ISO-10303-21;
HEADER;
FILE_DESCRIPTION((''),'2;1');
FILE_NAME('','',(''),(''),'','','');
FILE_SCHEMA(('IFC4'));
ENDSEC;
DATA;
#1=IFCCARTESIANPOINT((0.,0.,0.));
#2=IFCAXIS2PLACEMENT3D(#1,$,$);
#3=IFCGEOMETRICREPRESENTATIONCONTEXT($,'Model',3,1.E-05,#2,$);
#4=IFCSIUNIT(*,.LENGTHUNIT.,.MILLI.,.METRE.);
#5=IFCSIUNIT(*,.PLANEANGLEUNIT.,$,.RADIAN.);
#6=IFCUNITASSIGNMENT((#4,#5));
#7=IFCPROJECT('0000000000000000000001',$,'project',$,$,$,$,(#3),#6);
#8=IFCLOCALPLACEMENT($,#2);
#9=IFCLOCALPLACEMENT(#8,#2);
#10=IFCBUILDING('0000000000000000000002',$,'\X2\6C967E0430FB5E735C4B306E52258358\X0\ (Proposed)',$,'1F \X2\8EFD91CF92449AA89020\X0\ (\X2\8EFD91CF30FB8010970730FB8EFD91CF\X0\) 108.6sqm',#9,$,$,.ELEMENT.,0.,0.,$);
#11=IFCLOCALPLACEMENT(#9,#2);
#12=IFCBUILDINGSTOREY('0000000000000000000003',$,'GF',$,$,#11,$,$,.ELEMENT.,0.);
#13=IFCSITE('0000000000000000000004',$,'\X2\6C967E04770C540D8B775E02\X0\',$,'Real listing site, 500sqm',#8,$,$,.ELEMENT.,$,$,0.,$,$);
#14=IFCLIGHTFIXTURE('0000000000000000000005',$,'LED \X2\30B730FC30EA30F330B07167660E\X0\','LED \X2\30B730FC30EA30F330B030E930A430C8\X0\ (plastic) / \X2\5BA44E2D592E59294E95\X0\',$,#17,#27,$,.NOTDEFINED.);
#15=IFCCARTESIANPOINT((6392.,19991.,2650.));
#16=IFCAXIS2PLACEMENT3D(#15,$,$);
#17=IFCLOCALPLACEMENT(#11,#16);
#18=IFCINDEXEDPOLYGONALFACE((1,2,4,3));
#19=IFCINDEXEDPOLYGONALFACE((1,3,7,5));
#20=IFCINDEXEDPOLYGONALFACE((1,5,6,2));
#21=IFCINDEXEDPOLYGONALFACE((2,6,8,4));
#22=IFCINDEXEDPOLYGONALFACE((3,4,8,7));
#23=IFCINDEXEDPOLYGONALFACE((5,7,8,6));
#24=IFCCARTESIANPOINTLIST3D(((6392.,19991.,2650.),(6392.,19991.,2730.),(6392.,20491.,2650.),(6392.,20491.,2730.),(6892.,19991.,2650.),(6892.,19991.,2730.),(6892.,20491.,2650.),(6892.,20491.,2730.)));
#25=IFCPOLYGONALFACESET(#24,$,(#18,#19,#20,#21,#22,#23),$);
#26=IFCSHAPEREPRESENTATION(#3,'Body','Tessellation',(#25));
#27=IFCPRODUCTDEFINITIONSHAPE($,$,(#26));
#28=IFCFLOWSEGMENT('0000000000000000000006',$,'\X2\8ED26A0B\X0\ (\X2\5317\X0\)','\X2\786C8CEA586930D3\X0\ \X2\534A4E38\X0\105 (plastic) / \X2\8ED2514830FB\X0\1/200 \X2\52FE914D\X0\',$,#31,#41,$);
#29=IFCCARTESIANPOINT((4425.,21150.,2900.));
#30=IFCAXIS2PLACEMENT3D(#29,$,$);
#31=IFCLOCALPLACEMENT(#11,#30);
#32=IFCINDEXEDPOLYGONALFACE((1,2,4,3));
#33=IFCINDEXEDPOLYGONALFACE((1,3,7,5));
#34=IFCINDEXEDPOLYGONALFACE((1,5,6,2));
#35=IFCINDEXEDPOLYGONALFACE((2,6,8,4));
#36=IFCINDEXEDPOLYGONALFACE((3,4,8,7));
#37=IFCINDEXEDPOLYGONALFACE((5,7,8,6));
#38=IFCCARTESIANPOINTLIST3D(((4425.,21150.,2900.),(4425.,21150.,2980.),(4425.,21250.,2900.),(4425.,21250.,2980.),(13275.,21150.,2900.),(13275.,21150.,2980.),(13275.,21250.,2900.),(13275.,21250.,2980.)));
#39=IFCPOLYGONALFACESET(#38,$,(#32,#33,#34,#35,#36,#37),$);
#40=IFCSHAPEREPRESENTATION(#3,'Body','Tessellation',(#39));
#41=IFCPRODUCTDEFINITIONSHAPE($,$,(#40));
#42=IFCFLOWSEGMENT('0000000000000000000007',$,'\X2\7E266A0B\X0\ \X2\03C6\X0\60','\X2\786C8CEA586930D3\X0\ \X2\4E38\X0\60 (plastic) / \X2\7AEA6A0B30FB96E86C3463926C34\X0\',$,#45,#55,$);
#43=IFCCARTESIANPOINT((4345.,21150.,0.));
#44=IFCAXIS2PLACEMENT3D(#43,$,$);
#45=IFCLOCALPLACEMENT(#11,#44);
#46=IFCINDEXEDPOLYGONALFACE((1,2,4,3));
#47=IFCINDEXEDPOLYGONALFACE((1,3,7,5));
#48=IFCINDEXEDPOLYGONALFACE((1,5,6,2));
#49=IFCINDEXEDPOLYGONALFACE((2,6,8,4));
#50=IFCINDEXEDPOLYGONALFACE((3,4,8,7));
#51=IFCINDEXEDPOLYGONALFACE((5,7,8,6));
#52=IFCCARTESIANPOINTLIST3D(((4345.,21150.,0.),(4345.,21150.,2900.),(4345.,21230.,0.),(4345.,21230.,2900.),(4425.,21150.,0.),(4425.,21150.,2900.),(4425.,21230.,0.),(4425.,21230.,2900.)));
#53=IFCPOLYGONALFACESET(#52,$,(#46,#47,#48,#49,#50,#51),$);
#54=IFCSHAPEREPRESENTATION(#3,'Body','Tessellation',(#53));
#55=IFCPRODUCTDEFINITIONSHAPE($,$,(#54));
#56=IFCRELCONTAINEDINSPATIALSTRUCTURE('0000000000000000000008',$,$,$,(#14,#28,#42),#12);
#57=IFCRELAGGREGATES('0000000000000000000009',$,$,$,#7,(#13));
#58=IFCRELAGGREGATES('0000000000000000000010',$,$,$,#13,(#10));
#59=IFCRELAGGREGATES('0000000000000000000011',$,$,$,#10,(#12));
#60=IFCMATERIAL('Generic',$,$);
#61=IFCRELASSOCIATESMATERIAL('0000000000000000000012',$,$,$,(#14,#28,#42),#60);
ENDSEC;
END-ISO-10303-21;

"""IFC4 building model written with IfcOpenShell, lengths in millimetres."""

from ifc_helpers import new_model, si_unit, frame, frame_2d, origin, place, context, project, spatial, rectangle, extrude, material, element, save


model = new_model("IFC4")

# Units and contexts
model_context = context("Model", 3, precision=1e-05, world=origin())
ifc_project = project(units=[si_unit("LENGTHUNIT", "METRE", prefix="MILLI"), si_unit("PLANEANGLEUNIT", "RADIAN")], contexts=[model_context])

# Site, building, storey
site_placement = place(None, origin())
site = spatial("IfcSite", under=ifc_project, at=site_placement, Name="沖縄県名護市", ObjectType="Real listing site, 500sqm", CompositionType="ELEMENT", RefElevation=0.0)
building_placement = place(site_placement, origin())
building = spatial("IfcBuilding", under=site, at=building_placement, Name="沖縄・平屋の別荘 (Proposed)", ObjectType="1F 軽量鉄骨造 (軽量・耐震・軽量) 108.6sqm", CompositionType="ELEMENT", ElevationOfRefHeight=0.0, ElevationOfTerrain=0.0)
storey_placement = place(building_placement, origin())
storey = spatial("IfcBuildingStorey", under=building, at=storey_placement, Name="GF", CompositionType="ELEMENT", Elevation=0.0)

# Shared definitions
ifc_material_1 = material(Name="Generic")

# Light fixture
light_fixture_placement = place(storey_placement, frame((6392.0, 19991.0, 2650.0)))
element("IfcLightFixture", 1, at=light_fixture_placement, inside=storey, material=ifc_material_1, Name="LED シーリング照明", Description="LED シーリングライト (plastic) / 室中央天井", PredefinedType="NOTDEFINED", context=model_context, shape_type="SweptSolid", body=[
    extrude(rectangle(XDim=500.0, YDim=500.0, at=frame_2d((250.0, 250.0))), frame((6392.0, 19991.0, 2650.0)), (0.0, 0.0, 1.0), 80.0),
])

# Flow segments
flow_segment_1_placement = place(storey_placement, frame((4425.0, 21150.0, 2900.0)))
element("IfcFlowSegment", 2, at=flow_segment_1_placement, inside=storey, material=ifc_material_1, Name="軒樋 (北)", Description="硬質塩ビ 半丸105 (plastic) / 軒先・1/200 勾配", context=model_context, shape_type="SweptSolid", body=[
    extrude(rectangle(XDim=8850.0, YDim=100.0, at=frame_2d((4425.0, 50.0))), frame((4425.0, 21150.0, 2900.0)), (0.0, 0.0, 1.0), 80.0),
])
flow_segment_2_placement = place(storey_placement, frame((4345.0, 21150.0, 0.0)))
element("IfcFlowSegment", 3, at=flow_segment_2_placement, inside=storey, material=ifc_material_1, Name="縦樋 φ60", Description="硬質塩ビ 丸60 (plastic) / 竪樋・雨水排水", context=model_context, shape_type="SweptSolid", body=[
    extrude(rectangle(XDim=80.0, YDim=80.0, at=frame_2d((40.0, 40.0))), frame((4345.0, 21150.0, 0.0)), (0.0, 0.0, 1.0), 2900.0),
])

save(model, "model.ifc")
